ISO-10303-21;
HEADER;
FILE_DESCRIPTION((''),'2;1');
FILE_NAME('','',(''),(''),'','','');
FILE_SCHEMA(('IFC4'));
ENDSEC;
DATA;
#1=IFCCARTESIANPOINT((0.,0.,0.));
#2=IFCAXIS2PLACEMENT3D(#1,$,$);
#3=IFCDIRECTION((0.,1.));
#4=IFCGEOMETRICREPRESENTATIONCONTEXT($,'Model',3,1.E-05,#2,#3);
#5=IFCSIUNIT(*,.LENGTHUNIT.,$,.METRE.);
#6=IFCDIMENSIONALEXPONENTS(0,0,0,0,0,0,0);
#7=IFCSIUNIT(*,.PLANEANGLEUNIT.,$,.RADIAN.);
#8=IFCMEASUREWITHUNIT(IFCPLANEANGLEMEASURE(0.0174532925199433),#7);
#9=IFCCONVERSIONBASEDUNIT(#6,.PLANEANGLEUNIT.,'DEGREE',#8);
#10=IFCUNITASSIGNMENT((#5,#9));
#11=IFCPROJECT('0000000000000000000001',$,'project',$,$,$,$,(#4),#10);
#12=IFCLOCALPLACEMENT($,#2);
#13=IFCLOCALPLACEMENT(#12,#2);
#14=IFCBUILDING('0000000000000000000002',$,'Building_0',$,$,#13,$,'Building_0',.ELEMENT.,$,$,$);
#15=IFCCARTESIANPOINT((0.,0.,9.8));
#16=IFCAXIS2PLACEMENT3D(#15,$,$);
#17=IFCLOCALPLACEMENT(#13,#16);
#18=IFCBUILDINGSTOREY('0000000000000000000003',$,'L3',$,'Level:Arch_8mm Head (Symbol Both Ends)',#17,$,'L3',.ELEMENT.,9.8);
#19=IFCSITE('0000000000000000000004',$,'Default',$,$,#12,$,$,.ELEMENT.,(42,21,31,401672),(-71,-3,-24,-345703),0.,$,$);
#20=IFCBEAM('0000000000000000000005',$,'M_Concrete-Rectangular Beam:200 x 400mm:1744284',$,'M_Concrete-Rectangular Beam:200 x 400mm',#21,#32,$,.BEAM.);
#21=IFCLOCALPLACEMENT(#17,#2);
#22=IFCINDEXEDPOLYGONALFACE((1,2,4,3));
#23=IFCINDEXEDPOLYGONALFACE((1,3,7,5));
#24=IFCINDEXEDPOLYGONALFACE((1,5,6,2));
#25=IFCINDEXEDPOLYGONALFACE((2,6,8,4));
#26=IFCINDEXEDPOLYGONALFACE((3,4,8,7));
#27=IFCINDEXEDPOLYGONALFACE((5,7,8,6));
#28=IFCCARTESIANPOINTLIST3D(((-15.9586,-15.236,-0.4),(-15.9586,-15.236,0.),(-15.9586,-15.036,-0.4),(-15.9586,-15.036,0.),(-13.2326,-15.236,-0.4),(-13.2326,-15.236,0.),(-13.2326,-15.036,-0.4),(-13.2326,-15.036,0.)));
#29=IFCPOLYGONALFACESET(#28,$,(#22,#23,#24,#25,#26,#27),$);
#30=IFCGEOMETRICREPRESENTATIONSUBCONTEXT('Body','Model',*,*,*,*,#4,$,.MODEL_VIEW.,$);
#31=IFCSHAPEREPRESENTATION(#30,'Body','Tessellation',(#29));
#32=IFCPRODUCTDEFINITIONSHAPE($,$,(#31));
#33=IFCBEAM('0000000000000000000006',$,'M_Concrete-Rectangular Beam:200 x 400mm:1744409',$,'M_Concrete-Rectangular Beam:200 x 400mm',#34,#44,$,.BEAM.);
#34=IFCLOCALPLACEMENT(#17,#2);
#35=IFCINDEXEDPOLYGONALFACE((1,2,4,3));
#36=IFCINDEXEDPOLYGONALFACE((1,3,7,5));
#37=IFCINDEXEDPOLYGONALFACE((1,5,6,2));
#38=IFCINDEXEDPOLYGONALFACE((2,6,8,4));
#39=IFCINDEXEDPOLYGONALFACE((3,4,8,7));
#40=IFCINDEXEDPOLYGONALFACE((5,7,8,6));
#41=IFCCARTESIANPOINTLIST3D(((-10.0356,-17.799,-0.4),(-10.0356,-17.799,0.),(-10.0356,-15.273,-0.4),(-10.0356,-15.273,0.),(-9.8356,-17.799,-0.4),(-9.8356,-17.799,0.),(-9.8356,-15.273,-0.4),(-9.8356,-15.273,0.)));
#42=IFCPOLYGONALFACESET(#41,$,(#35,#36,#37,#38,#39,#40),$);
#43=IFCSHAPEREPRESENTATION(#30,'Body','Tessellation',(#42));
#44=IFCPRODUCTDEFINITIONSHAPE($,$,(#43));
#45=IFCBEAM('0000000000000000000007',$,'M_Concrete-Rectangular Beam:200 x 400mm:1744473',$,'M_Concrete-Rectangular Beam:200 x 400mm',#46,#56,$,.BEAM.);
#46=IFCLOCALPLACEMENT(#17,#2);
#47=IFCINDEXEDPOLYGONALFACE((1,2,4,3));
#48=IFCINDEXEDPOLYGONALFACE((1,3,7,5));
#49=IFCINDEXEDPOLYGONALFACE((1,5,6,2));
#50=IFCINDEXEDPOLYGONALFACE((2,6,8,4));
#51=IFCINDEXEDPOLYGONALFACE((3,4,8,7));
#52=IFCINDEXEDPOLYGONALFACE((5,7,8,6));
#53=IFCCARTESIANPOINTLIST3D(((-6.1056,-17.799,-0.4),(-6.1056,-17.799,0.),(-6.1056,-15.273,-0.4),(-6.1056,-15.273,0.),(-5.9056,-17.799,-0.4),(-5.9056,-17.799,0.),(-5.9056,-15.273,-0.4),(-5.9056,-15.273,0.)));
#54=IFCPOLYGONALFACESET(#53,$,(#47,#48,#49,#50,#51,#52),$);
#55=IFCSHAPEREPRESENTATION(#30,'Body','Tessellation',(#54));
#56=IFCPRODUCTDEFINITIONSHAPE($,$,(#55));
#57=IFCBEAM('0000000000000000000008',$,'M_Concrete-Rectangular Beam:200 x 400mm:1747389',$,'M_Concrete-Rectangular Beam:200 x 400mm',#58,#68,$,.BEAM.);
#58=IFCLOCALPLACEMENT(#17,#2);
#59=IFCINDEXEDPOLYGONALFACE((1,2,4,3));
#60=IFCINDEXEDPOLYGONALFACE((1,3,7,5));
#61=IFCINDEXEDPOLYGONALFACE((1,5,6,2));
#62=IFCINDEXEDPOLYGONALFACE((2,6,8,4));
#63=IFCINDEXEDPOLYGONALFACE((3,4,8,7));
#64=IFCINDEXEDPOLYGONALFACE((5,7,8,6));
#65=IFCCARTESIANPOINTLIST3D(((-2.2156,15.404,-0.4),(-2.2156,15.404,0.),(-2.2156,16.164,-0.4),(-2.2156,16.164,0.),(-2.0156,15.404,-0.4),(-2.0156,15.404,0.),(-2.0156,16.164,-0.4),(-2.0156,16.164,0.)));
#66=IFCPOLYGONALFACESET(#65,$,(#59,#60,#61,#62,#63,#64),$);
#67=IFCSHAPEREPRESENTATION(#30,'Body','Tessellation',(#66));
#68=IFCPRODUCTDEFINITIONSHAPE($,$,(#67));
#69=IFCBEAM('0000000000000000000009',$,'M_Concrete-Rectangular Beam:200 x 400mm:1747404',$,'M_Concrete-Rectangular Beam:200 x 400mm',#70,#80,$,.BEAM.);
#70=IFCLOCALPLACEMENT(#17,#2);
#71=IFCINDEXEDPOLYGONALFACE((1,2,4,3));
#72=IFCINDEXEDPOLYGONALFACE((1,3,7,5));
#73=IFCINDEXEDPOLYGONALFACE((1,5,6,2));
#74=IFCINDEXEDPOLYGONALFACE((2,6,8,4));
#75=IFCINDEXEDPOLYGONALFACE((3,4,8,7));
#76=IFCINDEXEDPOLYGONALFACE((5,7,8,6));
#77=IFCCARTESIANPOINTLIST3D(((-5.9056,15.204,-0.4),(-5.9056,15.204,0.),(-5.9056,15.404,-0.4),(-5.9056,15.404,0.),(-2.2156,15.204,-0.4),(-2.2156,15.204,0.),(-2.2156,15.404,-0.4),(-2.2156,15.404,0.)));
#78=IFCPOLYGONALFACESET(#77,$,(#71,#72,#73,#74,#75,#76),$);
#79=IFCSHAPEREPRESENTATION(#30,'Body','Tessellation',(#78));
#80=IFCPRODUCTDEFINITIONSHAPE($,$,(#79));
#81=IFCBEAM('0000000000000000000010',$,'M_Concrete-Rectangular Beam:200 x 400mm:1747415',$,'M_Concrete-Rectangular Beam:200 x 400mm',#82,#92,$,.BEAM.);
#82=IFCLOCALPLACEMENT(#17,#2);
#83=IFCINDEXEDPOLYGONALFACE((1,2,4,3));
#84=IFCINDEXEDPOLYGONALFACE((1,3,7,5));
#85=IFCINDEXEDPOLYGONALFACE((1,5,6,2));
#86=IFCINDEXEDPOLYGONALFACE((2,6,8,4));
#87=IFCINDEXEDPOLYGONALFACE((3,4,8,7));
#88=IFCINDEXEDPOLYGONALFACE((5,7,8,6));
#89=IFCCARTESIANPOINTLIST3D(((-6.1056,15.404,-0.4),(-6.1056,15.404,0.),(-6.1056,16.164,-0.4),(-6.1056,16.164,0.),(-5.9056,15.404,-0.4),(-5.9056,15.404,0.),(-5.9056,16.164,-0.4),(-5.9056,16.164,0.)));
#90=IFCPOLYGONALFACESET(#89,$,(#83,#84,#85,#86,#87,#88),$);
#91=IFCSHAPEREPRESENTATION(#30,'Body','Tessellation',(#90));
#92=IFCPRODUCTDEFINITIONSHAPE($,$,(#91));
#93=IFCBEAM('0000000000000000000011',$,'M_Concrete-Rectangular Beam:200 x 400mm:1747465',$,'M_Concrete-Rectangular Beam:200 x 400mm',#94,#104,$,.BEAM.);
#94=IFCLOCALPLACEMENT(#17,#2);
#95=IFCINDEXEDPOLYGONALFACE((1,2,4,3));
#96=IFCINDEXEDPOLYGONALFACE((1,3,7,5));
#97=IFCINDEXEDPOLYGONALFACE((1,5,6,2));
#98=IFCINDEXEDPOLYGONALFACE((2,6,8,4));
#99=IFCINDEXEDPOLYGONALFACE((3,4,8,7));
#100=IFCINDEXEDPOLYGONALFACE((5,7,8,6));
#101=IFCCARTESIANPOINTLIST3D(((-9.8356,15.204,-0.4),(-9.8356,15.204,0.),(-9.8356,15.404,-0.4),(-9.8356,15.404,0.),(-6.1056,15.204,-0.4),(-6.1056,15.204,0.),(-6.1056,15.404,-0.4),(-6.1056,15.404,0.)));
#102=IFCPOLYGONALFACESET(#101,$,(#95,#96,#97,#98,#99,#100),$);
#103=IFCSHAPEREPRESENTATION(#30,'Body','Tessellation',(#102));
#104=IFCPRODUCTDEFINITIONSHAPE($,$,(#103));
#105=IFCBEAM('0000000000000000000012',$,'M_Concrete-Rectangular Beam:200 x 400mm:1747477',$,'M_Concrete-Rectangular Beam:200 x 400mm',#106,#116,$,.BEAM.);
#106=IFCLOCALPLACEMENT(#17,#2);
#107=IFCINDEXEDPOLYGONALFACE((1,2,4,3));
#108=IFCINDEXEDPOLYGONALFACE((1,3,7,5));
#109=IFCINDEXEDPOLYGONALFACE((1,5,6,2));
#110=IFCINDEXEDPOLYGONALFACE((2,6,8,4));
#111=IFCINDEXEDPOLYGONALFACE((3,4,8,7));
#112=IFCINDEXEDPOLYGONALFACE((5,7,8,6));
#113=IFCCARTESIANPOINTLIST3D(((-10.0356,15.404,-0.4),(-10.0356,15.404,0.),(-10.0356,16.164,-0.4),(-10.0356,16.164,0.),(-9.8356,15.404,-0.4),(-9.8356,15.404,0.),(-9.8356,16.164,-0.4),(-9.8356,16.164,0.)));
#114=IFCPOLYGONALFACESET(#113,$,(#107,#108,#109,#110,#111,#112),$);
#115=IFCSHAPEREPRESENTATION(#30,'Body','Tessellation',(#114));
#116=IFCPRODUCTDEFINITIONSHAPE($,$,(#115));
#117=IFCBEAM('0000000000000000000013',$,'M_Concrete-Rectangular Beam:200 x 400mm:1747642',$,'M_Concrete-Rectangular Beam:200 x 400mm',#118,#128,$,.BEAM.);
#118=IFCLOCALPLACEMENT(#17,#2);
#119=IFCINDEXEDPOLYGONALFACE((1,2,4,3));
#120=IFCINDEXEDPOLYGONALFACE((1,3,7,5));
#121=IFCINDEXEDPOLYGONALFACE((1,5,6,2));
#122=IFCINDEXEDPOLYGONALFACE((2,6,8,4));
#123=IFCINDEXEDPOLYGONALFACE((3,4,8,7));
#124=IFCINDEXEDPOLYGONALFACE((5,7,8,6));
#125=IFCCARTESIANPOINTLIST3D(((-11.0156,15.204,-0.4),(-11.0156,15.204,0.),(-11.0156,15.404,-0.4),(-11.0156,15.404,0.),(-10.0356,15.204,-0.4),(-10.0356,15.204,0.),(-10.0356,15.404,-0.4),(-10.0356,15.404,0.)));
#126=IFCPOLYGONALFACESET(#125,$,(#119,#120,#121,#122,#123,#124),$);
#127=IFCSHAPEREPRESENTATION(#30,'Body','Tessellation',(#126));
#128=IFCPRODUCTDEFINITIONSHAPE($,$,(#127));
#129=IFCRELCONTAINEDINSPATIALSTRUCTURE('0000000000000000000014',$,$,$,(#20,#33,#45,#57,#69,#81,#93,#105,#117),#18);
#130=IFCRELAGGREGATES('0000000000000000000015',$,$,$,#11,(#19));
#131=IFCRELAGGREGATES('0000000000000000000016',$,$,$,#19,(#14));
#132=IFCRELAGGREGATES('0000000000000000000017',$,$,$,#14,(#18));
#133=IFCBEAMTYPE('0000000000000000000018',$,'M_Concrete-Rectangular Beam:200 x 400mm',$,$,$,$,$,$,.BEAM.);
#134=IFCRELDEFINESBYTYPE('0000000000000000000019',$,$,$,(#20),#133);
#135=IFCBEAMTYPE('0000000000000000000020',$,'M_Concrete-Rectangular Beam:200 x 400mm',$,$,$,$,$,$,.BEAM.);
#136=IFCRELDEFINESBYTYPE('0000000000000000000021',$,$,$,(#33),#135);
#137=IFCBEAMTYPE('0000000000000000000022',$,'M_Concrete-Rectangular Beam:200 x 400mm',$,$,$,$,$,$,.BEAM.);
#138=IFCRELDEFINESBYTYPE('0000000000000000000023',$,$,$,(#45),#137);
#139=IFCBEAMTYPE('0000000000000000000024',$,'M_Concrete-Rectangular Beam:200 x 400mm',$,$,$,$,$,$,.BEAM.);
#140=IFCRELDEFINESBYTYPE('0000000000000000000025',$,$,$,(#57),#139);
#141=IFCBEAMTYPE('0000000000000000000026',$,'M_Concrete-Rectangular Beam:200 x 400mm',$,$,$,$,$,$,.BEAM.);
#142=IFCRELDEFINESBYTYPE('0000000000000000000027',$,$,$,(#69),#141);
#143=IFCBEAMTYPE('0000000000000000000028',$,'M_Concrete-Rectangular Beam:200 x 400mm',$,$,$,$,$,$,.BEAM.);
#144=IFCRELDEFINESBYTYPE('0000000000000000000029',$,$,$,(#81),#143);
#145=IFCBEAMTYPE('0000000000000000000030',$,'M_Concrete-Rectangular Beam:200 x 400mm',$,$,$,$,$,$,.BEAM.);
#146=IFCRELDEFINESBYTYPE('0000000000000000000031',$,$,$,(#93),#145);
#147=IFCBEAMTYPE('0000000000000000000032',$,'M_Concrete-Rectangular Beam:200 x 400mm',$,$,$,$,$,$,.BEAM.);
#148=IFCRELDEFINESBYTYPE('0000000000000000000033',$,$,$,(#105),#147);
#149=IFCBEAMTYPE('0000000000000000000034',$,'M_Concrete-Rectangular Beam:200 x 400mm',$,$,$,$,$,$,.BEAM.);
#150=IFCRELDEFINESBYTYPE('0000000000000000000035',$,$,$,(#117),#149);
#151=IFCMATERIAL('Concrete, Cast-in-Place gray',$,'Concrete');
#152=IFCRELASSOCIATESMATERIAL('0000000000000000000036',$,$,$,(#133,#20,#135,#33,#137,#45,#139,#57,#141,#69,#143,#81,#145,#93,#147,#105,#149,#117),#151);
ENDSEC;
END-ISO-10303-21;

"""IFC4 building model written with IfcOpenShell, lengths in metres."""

from ifc_helpers import new_model, entity, si_unit, converted_unit, direction, frame, origin, place, context, subcontext, project, spatial, indexed_curve, outline, extrude, source, transform, mapped, material, type_object, type_shapes, element, save


model = new_model("IFC4")

# Units and contexts
model_context = context("Model", 3, precision=1e-05, world=origin(), true_north=direction((0.0, 1.0)))
body_context = subcontext(model_context, "Body", "Model", "MODEL_VIEW")
ifc_project = project(units=[si_unit("LENGTHUNIT", "METRE"), converted_unit("PLANEANGLEUNIT", "DEGREE", entity("IfcPlaneAngleMeasure", 0.0174532925199433), si_unit("PLANEANGLEUNIT", "RADIAN"), dimensions=[0, 0, 0, 0, 0, 0, 0])], contexts=[model_context])

# Site, building, storey
site_placement = place(None, origin())
site = spatial("IfcSite", under=ifc_project, at=site_placement, Name="Default", CompositionType="ELEMENT", RefLatitude=(42, 21, 31, 401672), RefLongitude=(-71, -3, -24, -345703), RefElevation=0.0)
building_placement = place(site_placement, origin())
building = spatial("IfcBuilding", under=site, at=building_placement, Name="Building_0", LongName="Building_0", CompositionType="ELEMENT")
storey_placement = place(building_placement, frame((0.0, 0.0, 9.8)))
storey = spatial("IfcBuildingStorey", under=building, at=storey_placement, Name="L3", ObjectType="Level:Arch_8mm Head (Symbol Both Ends)", LongName="L3", CompositionType="ELEMENT", Elevation=9.8)

# Beams
ifc_material = material(Name="Concrete, Cast-in-Place gray", Category="Concrete")
beam_type_1 = type_object("IfcBeamType", Name="M_Concrete-Rectangular Beam:200 x 400mm", PredefinedType="BEAM", material=ifc_material)
shared_shape_1 = source(origin(), body_context, "Body", "SweptSolid", [
    extrude(outline(indexed_curve([(-0.2, -0.1), (0.2, -0.1), (0.2, 0.1), (-0.2, 0.1), (-0.2, -0.1)], self_intersect=False)), frame((-13.2326, -15.136, 9.6), z_axis=(-1.0, 0.0, 0.0), x_axis=(0.0, 0.0, -1.0)), (0.0, 0.0, 1.0), 2.726),
])
type_shapes(beam_type_1, [shared_shape_1])
beam_1_placement = place(storey_placement, frame((0.0, 0.0, -9.8)))
element("IfcBeam", 1, at=beam_1_placement, inside=storey, type_object=beam_type_1, material=ifc_material, Name="M_Concrete-Rectangular Beam:200 x 400mm:1744284", ObjectType="M_Concrete-Rectangular Beam:200 x 400mm", PredefinedType="BEAM", context=body_context, shape_type="MappedRepresentation", body=[
    mapped(shared_shape_1, transform((0.0, 0.0, 0.0), scale=1.0)),
])
beam_type_2 = type_object("IfcBeamType", Name="M_Concrete-Rectangular Beam:200 x 400mm", PredefinedType="BEAM", material=ifc_material)
shared_shape_2 = source(origin(), body_context, "Body", "SweptSolid", [
    extrude(outline(indexed_curve([(-0.1, -0.2), (0.1, -0.2), (0.1, 0.2), (-0.1, 0.2), (-0.1, -0.2)], self_intersect=False)), frame((-9.9356, -15.273, 9.6), z_axis=(0.0, -1.0, 0.0), x_axis=(-1.0, 0.0, 0.0)), (0.0, 0.0, 1.0), 2.526),
])
type_shapes(beam_type_2, [shared_shape_2])
beam_2_placement = place(storey_placement, frame((0.0, 0.0, -9.8)))
element("IfcBeam", 2, at=beam_2_placement, inside=storey, type_object=beam_type_2, material=ifc_material, Name="M_Concrete-Rectangular Beam:200 x 400mm:1744409", ObjectType="M_Concrete-Rectangular Beam:200 x 400mm", PredefinedType="BEAM", context=body_context, shape_type="MappedRepresentation", body=[
    mapped(shared_shape_2, transform((0.0, 0.0, 0.0), scale=1.0)),
])
beam_type_3 = type_object("IfcBeamType", Name="M_Concrete-Rectangular Beam:200 x 400mm", PredefinedType="BEAM", material=ifc_material)
shared_shape_3 = source(origin(), body_context, "Body", "SweptSolid", [
    extrude(outline(indexed_curve([(-0.1, -0.2), (0.1, -0.2), (0.1, 0.2), (-0.1, 0.2), (-0.1, -0.2)], self_intersect=False)), frame((-6.0056, -15.273, 9.6), z_axis=(0.0, -1.0, 0.0), x_axis=(-1.0, 0.0, 0.0)), (0.0, 0.0, 1.0), 2.526),
])
type_shapes(beam_type_3, [shared_shape_3])
beam_3_placement = place(storey_placement, frame((0.0, 0.0, -9.8)))
element("IfcBeam", 3, at=beam_3_placement, inside=storey, type_object=beam_type_3, material=ifc_material, Name="M_Concrete-Rectangular Beam:200 x 400mm:1744473", ObjectType="M_Concrete-Rectangular Beam:200 x 400mm", PredefinedType="BEAM", context=body_context, shape_type="MappedRepresentation", body=[
    mapped(shared_shape_3, transform((0.0, 0.0, 0.0), scale=1.0)),
])
beam_type_4 = type_object("IfcBeamType", Name="M_Concrete-Rectangular Beam:200 x 400mm", PredefinedType="BEAM", material=ifc_material)
shared_shape_4 = source(origin(), body_context, "Body", "SweptSolid", [
    extrude(outline(indexed_curve([(-0.1, -0.2), (0.1, -0.2), (0.1, 0.2), (-0.1, 0.2), (-0.1, -0.2)], self_intersect=False)), frame((-2.1156, 16.164, 9.6), z_axis=(0.0, -1.0, 0.0), x_axis=(-1.0, 0.0, 0.0)), (0.0, 0.0, 1.0), 0.76),
])
type_shapes(beam_type_4, [shared_shape_4])
beam_4_placement = place(storey_placement, frame((0.0, 0.0, -9.8)))
element("IfcBeam", 4, at=beam_4_placement, inside=storey, type_object=beam_type_4, material=ifc_material, Name="M_Concrete-Rectangular Beam:200 x 400mm:1747389", ObjectType="M_Concrete-Rectangular Beam:200 x 400mm", PredefinedType="BEAM", context=body_context, shape_type="MappedRepresentation", body=[
    mapped(shared_shape_4, transform((0.0, 0.0, 0.0), scale=1.0)),
])
beam_type_5 = type_object("IfcBeamType", Name="M_Concrete-Rectangular Beam:200 x 400mm", PredefinedType="BEAM", material=ifc_material)
shared_shape_5 = source(origin(), body_context, "Body", "SweptSolid", [
    extrude(outline(indexed_curve([(-0.2, -0.1), (0.2, -0.1), (0.2, 0.1), (-0.2, 0.1), (-0.2, -0.1)], self_intersect=False)), frame((-2.2156, 15.304, 9.6), z_axis=(-1.0, 0.0, 0.0), x_axis=(0.0, 0.0, -1.0)), (0.0, 0.0, 1.0), 3.69),
])
type_shapes(beam_type_5, [shared_shape_5])
beam_5_placement = place(storey_placement, frame((0.0, 0.0, -9.8)))
element("IfcBeam", 5, at=beam_5_placement, inside=storey, type_object=beam_type_5, material=ifc_material, Name="M_Concrete-Rectangular Beam:200 x 400mm:1747404", ObjectType="M_Concrete-Rectangular Beam:200 x 400mm", PredefinedType="BEAM", context=body_context, shape_type="MappedRepresentation", body=[
    mapped(shared_shape_5, transform((0.0, 0.0, 0.0), scale=1.0)),
])
beam_type_6 = type_object("IfcBeamType", Name="M_Concrete-Rectangular Beam:200 x 400mm", PredefinedType="BEAM", material=ifc_material)
shared_shape_6 = source(origin(), body_context, "Body", "SweptSolid", [
    extrude(outline(indexed_curve([(-0.1, -0.2), (0.1, -0.2), (0.1, 0.2), (-0.1, 0.2), (-0.1, -0.2)], self_intersect=False)), frame((-6.0056, 15.404, 9.6), z_axis=(0.0, 1.0, 0.0), x_axis=(-1.0, 0.0, 0.0)), (0.0, 0.0, 1.0), 0.76),
])
type_shapes(beam_type_6, [shared_shape_6])
beam_6_placement = place(storey_placement, frame((0.0, 0.0, -9.8)))
element("IfcBeam", 6, at=beam_6_placement, inside=storey, type_object=beam_type_6, material=ifc_material, Name="M_Concrete-Rectangular Beam:200 x 400mm:1747415", ObjectType="M_Concrete-Rectangular Beam:200 x 400mm", PredefinedType="BEAM", context=body_context, shape_type="MappedRepresentation", body=[
    mapped(shared_shape_6, transform((0.0, 0.0, 0.0), scale=1.0)),
])
beam_type_7 = type_object("IfcBeamType", Name="M_Concrete-Rectangular Beam:200 x 400mm", PredefinedType="BEAM", material=ifc_material)
shared_shape_7 = source(origin(), body_context, "Body", "SweptSolid", [
    extrude(outline(indexed_curve([(-0.2, -0.1), (0.2, -0.1), (0.2, 0.1), (-0.2, 0.1), (-0.2, -0.1)], self_intersect=False)), frame((-6.1056, 15.304, 9.6), z_axis=(-1.0, 0.0, 0.0), x_axis=(0.0, 0.0, -1.0)), (0.0, 0.0, 1.0), 3.73),
])
type_shapes(beam_type_7, [shared_shape_7])
beam_7_placement = place(storey_placement, frame((0.0, 0.0, -9.8)))
element("IfcBeam", 7, at=beam_7_placement, inside=storey, type_object=beam_type_7, material=ifc_material, Name="M_Concrete-Rectangular Beam:200 x 400mm:1747465", ObjectType="M_Concrete-Rectangular Beam:200 x 400mm", PredefinedType="BEAM", context=body_context, shape_type="MappedRepresentation", body=[
    mapped(shared_shape_7, transform((0.0, 0.0, 0.0), scale=1.0)),
])
beam_type_8 = type_object("IfcBeamType", Name="M_Concrete-Rectangular Beam:200 x 400mm", PredefinedType="BEAM", material=ifc_material)
shared_shape_8 = source(origin(), body_context, "Body", "SweptSolid", [
    extrude(outline(indexed_curve([(-0.1, -0.2), (0.1, -0.2), (0.1, 0.2), (-0.1, 0.2), (-0.1, -0.2)], self_intersect=False)), frame((-9.9356, 15.404, 9.6), z_axis=(0.0, 1.0, 0.0), x_axis=(-1.0, 0.0, 0.0)), (0.0, 0.0, 1.0), 0.76),
])
type_shapes(beam_type_8, [shared_shape_8])
beam_8_placement = place(storey_placement, frame((0.0, 0.0, -9.8)))
element("IfcBeam", 8, at=beam_8_placement, inside=storey, type_object=beam_type_8, material=ifc_material, Name="M_Concrete-Rectangular Beam:200 x 400mm:1747477", ObjectType="M_Concrete-Rectangular Beam:200 x 400mm", PredefinedType="BEAM", context=body_context, shape_type="MappedRepresentation", body=[
    mapped(shared_shape_8, transform((0.0, 0.0, 0.0), scale=1.0)),
])
beam_type_9 = type_object("IfcBeamType", Name="M_Concrete-Rectangular Beam:200 x 400mm", PredefinedType="BEAM", material=ifc_material)
shared_shape_9 = source(origin(), body_context, "Body", "SweptSolid", [
    extrude(outline(indexed_curve([(-0.2, -0.1), (0.2, -0.1), (0.2, 0.1), (-0.2, 0.1), (-0.2, -0.1)], self_intersect=False)), frame((-10.0356, 15.304, 9.6), z_axis=(-1.0, 0.0, 0.0), x_axis=(0.0, 0.0, -1.0)), (0.0, 0.0, 1.0), 0.98),
])
type_shapes(beam_type_9, [shared_shape_9])
beam_9_placement = place(storey_placement, frame((0.0, 0.0, -9.8)))
element("IfcBeam", 9, at=beam_9_placement, inside=storey, type_object=beam_type_9, material=ifc_material, Name="M_Concrete-Rectangular Beam:200 x 400mm:1747642", ObjectType="M_Concrete-Rectangular Beam:200 x 400mm", PredefinedType="BEAM", context=body_context, shape_type="MappedRepresentation", body=[
    mapped(shared_shape_9, transform((0.0, 0.0, 0.0), scale=1.0)),
])

save(model, "model.ifc")
